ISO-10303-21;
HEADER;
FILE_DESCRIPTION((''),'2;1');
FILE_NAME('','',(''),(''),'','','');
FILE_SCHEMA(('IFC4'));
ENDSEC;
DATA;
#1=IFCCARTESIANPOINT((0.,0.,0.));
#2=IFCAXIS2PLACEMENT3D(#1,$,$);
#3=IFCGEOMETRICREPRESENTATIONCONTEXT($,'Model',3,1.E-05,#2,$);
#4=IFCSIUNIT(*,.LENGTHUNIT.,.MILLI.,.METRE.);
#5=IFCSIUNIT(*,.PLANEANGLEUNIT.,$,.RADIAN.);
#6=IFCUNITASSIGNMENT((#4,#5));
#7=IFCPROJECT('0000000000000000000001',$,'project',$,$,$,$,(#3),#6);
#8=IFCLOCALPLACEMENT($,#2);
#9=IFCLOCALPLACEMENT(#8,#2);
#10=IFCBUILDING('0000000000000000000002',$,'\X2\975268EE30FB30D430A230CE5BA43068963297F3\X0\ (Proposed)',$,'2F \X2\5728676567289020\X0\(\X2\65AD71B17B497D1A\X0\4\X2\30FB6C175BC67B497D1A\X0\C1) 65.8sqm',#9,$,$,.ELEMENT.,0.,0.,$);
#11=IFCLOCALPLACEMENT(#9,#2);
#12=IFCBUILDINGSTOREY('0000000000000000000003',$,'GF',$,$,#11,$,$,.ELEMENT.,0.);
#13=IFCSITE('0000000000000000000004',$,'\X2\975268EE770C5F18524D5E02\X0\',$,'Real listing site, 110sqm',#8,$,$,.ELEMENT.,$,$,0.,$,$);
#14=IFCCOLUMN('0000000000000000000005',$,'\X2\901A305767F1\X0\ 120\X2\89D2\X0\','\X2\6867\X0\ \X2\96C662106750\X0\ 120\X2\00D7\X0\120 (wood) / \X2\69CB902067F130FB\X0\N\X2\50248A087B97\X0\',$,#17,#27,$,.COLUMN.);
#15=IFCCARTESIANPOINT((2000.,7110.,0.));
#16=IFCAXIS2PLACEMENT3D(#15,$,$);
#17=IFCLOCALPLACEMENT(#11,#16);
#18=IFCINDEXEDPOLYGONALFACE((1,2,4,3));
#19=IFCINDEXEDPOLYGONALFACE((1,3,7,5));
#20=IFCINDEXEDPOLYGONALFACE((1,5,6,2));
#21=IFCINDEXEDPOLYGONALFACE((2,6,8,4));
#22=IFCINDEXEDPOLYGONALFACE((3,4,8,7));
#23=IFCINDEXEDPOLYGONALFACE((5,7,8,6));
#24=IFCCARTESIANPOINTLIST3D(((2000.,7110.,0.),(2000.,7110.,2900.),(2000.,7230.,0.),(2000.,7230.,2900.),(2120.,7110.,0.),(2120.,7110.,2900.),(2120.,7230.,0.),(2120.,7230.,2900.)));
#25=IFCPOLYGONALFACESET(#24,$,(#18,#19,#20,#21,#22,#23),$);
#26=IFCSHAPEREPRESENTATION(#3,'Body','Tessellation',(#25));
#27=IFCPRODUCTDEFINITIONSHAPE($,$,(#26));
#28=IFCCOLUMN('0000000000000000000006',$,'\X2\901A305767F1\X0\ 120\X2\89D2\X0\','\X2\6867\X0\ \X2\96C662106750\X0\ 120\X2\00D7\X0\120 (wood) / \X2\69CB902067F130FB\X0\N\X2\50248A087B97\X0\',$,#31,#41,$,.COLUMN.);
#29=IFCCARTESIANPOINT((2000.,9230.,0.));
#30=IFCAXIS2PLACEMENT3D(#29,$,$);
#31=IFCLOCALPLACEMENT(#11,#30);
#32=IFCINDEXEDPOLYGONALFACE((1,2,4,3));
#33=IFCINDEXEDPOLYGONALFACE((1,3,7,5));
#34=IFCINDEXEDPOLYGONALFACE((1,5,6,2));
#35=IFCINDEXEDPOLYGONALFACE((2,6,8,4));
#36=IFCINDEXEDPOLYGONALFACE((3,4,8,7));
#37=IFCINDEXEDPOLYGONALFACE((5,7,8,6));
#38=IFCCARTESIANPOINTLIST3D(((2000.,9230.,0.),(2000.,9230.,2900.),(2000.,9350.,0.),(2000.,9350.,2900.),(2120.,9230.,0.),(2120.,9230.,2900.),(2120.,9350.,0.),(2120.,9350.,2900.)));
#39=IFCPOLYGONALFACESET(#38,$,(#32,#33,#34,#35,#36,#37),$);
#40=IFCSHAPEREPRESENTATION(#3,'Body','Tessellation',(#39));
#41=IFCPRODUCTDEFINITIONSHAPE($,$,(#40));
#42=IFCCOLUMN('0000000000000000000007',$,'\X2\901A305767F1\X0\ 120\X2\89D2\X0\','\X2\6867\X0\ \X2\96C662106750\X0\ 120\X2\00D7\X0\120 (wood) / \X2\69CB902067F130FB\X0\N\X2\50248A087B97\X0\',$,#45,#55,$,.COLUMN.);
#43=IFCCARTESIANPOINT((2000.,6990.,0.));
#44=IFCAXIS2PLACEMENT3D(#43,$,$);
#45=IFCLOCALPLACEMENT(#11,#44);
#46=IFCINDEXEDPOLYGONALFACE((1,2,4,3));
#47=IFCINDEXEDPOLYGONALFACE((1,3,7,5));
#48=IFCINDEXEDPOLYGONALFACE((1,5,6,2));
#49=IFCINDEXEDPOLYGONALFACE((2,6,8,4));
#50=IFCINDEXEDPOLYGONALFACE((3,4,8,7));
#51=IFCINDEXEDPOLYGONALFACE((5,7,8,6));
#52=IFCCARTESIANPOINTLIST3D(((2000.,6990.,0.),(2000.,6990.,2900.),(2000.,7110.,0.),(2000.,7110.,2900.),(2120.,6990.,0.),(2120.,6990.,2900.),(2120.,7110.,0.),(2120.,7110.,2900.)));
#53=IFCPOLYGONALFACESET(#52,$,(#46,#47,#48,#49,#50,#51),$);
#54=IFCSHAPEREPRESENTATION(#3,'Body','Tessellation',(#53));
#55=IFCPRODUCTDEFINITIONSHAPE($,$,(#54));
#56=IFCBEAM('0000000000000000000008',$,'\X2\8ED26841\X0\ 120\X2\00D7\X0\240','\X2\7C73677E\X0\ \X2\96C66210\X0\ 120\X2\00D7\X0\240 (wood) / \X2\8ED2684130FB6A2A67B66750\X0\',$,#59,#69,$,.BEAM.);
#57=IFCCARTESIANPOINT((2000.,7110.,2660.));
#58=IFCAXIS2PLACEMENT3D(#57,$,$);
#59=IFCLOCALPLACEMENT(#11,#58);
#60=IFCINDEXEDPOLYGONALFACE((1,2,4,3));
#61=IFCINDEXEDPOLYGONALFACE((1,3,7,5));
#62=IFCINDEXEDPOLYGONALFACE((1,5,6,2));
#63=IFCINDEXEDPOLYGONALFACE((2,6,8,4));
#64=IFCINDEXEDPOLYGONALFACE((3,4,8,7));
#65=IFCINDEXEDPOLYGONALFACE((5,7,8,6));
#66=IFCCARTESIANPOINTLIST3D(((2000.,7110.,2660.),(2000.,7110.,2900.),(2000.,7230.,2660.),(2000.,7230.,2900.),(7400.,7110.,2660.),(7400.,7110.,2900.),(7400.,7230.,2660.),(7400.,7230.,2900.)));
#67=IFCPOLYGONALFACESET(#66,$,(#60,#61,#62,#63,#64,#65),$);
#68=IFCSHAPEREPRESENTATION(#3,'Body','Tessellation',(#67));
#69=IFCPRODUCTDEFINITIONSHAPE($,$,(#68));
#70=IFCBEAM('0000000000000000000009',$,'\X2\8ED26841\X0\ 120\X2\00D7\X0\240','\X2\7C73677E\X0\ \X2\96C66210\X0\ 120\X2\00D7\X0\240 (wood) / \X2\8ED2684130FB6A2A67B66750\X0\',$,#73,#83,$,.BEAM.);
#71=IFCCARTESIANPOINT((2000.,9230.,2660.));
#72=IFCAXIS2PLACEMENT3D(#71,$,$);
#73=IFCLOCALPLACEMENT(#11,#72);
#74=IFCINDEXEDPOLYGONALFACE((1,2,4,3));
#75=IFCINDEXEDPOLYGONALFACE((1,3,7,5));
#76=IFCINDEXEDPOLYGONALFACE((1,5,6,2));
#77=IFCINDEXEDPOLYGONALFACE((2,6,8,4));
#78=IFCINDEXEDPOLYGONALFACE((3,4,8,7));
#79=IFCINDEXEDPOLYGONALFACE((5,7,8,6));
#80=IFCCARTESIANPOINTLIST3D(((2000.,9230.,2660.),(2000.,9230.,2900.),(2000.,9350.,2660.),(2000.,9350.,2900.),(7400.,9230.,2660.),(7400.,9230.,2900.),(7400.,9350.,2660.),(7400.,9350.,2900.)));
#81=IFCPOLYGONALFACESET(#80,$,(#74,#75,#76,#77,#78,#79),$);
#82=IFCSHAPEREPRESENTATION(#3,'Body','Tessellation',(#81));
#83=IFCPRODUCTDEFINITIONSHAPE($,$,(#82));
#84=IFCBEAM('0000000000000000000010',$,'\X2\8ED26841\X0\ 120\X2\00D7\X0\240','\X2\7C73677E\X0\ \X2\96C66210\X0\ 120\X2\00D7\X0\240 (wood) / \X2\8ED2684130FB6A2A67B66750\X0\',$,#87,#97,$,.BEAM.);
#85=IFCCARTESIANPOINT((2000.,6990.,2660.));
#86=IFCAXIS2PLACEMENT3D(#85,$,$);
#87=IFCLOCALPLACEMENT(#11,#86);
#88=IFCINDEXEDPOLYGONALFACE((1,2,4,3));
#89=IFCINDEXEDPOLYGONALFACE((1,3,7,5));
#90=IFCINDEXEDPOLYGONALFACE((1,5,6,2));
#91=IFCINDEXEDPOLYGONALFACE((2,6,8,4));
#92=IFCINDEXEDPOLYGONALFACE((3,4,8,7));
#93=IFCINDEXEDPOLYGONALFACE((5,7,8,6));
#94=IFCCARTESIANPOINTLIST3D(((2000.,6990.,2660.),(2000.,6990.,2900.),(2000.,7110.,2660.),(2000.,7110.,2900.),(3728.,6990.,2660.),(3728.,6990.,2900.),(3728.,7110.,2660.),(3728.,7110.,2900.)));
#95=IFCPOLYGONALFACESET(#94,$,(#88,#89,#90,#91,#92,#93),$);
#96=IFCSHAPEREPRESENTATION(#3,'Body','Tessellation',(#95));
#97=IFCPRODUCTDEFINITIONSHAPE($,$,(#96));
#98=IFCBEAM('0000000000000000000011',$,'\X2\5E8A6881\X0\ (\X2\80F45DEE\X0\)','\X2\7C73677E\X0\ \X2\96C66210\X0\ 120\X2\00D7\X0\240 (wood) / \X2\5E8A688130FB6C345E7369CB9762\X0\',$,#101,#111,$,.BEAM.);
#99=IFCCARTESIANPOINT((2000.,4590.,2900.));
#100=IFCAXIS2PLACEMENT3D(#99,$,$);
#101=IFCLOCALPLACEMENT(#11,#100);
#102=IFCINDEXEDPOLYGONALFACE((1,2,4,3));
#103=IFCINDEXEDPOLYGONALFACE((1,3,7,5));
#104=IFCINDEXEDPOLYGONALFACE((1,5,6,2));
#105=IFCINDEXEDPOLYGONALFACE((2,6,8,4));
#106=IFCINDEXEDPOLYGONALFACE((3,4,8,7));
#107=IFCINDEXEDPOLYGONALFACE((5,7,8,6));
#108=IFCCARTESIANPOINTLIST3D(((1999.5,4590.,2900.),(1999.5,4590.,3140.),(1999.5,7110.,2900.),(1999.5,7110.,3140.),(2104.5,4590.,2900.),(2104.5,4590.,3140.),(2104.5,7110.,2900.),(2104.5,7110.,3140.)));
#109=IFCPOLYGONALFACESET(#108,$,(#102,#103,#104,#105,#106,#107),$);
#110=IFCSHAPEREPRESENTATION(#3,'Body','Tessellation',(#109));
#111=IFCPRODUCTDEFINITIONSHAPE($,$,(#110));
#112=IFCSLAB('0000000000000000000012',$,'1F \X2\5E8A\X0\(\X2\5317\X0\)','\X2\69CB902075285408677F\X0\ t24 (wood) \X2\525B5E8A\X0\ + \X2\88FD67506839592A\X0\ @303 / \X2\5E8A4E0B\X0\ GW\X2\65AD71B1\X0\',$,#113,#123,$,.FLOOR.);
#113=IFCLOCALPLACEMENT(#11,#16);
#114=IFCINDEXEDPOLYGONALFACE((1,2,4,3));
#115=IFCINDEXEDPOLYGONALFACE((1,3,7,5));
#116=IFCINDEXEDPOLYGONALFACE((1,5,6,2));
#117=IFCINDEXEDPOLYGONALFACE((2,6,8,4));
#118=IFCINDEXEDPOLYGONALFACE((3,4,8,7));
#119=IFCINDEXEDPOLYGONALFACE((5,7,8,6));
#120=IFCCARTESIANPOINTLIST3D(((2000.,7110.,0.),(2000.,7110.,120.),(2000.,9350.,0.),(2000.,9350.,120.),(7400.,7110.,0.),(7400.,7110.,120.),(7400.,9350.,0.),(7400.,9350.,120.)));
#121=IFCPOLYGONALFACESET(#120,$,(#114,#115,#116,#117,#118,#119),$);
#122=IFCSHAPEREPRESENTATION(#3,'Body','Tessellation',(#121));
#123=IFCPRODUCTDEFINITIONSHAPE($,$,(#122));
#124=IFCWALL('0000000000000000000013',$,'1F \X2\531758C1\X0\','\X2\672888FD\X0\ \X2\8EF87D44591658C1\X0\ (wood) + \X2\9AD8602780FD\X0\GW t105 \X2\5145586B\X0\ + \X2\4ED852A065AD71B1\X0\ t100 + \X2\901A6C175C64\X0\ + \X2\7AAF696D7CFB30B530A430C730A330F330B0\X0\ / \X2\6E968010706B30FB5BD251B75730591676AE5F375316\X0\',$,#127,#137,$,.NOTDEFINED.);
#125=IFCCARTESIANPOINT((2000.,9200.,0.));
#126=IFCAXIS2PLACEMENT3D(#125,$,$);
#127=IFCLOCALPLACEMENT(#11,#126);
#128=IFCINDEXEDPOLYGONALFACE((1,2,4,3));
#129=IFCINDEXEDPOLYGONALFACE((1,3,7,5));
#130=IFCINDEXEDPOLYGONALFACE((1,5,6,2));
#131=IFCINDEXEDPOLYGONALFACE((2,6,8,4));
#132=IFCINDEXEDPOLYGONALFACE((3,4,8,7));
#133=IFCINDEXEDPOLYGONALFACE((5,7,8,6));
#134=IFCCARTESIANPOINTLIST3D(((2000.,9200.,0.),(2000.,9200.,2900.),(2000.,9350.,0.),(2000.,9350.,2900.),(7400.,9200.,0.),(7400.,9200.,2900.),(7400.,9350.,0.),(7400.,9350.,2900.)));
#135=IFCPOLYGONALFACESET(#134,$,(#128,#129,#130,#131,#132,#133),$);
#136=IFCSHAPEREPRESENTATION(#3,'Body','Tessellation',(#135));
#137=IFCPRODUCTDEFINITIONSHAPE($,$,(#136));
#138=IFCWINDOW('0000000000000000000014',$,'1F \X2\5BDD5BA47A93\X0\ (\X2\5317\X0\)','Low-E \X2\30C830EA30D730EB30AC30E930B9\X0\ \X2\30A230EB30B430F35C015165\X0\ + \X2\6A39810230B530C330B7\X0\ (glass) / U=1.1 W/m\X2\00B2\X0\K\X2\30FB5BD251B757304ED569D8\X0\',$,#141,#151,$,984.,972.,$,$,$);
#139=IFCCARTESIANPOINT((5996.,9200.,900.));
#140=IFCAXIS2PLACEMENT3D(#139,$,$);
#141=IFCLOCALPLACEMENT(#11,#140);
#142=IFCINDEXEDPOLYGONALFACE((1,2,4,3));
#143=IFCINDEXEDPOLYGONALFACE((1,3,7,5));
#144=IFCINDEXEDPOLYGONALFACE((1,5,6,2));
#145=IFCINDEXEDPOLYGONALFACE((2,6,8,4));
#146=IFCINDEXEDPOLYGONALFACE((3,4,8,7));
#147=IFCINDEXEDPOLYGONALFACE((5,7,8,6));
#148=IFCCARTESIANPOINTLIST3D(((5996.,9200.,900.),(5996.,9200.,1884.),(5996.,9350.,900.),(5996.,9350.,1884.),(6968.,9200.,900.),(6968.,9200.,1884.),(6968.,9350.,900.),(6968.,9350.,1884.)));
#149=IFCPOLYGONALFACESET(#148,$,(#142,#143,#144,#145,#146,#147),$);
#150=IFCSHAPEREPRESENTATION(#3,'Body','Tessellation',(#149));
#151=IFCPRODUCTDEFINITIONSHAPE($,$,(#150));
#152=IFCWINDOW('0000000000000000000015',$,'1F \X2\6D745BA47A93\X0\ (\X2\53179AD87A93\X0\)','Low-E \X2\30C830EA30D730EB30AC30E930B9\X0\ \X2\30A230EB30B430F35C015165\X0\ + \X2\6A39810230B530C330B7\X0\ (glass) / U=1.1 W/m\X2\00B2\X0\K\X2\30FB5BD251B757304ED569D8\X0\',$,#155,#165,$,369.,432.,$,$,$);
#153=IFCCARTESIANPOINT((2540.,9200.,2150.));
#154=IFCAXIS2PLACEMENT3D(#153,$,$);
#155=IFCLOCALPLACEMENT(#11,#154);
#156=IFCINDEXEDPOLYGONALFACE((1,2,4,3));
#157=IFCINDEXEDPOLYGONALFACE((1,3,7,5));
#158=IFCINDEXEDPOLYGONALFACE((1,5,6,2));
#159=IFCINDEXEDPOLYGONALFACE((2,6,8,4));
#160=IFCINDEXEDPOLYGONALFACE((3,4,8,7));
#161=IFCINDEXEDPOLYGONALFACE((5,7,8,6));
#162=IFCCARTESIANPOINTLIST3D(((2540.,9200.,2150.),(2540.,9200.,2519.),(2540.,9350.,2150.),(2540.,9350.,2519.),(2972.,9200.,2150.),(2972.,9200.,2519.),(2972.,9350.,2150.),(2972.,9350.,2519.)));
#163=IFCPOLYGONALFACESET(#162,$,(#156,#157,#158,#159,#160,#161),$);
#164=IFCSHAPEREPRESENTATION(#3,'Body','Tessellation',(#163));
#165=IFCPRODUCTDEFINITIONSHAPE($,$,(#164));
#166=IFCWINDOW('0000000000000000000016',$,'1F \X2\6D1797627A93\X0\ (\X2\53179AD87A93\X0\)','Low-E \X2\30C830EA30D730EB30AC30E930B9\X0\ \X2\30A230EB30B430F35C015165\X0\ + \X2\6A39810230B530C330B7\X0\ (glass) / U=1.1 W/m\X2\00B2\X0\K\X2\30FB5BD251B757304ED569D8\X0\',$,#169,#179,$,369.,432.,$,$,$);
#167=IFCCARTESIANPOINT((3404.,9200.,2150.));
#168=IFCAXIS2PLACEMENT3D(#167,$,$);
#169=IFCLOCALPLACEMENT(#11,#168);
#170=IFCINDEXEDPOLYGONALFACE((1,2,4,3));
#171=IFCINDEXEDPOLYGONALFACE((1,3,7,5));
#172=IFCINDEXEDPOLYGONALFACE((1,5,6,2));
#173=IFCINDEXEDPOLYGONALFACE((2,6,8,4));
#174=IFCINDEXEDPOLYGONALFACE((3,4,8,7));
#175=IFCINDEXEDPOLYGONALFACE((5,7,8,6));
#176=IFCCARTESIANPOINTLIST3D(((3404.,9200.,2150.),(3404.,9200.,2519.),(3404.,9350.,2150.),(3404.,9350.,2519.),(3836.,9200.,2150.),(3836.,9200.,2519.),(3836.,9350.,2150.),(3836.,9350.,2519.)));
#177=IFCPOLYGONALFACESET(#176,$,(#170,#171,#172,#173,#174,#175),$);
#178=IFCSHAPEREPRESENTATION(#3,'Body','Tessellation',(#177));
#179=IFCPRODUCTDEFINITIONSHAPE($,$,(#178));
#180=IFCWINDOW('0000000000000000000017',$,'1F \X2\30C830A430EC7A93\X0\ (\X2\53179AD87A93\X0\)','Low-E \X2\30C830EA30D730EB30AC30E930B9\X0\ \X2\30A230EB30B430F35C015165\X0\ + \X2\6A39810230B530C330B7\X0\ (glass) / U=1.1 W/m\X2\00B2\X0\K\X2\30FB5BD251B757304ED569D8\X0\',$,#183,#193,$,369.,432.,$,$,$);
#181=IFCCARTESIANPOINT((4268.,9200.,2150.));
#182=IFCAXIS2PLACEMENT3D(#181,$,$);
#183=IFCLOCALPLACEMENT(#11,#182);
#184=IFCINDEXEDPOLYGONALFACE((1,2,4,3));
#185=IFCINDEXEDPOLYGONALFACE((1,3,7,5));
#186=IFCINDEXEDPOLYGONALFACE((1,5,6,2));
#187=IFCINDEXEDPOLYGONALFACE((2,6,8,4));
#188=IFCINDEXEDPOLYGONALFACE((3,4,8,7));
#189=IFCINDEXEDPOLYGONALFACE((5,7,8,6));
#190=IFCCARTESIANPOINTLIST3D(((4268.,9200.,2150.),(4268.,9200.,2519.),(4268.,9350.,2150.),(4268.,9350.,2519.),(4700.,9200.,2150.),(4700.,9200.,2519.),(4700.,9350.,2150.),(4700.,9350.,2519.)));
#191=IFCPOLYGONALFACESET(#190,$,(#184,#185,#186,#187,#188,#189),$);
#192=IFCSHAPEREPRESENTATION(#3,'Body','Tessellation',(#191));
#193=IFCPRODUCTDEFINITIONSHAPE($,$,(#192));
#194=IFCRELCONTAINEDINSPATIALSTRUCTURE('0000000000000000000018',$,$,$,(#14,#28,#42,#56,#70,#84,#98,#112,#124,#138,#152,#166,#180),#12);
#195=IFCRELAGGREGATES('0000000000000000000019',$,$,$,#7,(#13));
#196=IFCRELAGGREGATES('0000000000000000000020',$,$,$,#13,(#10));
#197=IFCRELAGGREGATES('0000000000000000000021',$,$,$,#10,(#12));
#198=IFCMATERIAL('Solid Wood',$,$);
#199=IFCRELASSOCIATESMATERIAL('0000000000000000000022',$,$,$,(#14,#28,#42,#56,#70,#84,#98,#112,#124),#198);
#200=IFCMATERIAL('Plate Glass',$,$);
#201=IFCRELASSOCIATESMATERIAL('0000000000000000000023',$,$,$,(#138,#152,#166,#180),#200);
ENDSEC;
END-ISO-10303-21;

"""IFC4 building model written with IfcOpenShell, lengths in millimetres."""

from ifc_helpers import new_model, si_unit, frame, frame_2d, origin, place, context, project, spatial, rectangle, extrude, material, element, fill, save


model = new_model("IFC4")

# Units and contexts
model_context = context("Model", 3, precision=1e-05, world=origin())
ifc_project = project(units=[si_unit("LENGTHUNIT", "METRE", prefix="MILLI"), si_unit("PLANEANGLEUNIT", "RADIAN")], contexts=[model_context])

# Site, building, storey
site_placement = place(None, origin())
site = spatial("IfcSite", under=ifc_project, at=site_placement, Name="青森県弘前市", ObjectType="Real listing site, 110sqm", CompositionType="ELEMENT", RefElevation=0.0)
building_placement = place(site_placement, origin())
building = spatial("IfcBuilding", under=site, at=building_placement, Name="青森・ピアノ室と防音 (Proposed)", ObjectType="2F 在来木造(断熱等級4・気密等級C1) 65.8sqm", CompositionType="ELEMENT", ElevationOfRefHeight=0.0, ElevationOfTerrain=0.0)
storey_placement = place(building_placement, origin())
storey = spatial("IfcBuildingStorey", under=building, at=storey_placement, Name="GF", CompositionType="ELEMENT", Elevation=0.0)

# Columns
ifc_material_1 = material(Name="Solid Wood")
column_1_placement = place(storey_placement, frame((2000.0, 7110.0, 0.0)))
element("IfcColumn", 1, at=column_1_placement, inside=storey, material=ifc_material_1, Name="通し柱 120角", Description="桧 集成材 120×120 (wood) / 構造柱・N値計算", PredefinedType="COLUMN", context=model_context, shape_type="SweptSolid", body=[
    extrude(rectangle(XDim=120.0, YDim=120.0, at=frame_2d((60.0, 60.0))), frame((2000.0, 7110.0, 0.0)), (0.0, 0.0, 1.0), 2900.0),
])
column_2_placement = place(storey_placement, frame((2000.0, 9230.0, 0.0)))
element("IfcColumn", 2, at=column_2_placement, inside=storey, material=ifc_material_1, Name="通し柱 120角", Description="桧 集成材 120×120 (wood) / 構造柱・N値計算", PredefinedType="COLUMN", context=model_context, shape_type="SweptSolid", body=[
    extrude(rectangle(XDim=120.0, YDim=120.0, at=frame_2d((60.0, 60.0))), frame((2000.0, 9230.0, 0.0)), (0.0, 0.0, 1.0), 2900.0),
])
column_3_placement = place(storey_placement, frame((2000.0, 6990.0, 0.0)))
element("IfcColumn", 3, at=column_3_placement, inside=storey, material=ifc_material_1, Name="通し柱 120角", Description="桧 集成材 120×120 (wood) / 構造柱・N値計算", PredefinedType="COLUMN", context=model_context, shape_type="SweptSolid", body=[
    extrude(rectangle(XDim=120.0, YDim=120.0, at=frame_2d((60.0, 60.0))), frame((2000.0, 6990.0, 0.0)), (0.0, 0.0, 1.0), 2900.0),
])

# Beams
beam_1_placement = place(storey_placement, frame((2000.0, 7110.0, 2660.0)))
element("IfcBeam", 4, at=beam_1_placement, inside=storey, material=ifc_material_1, Name="軒桁 120×240", Description="米松 集成 120×240 (wood) / 軒桁・横架材", PredefinedType="BEAM", context=model_context, shape_type="SweptSolid", body=[
    extrude(rectangle(XDim=5400.0, YDim=120.0, at=frame_2d((2700.0, 60.0))), frame((2000.0, 7110.0, 2660.0)), (0.0, 0.0, 1.0), 240.0),
])
beam_2_placement = place(storey_placement, frame((2000.0, 9230.0, 2660.0)))
element("IfcBeam", 5, at=beam_2_placement, inside=storey, material=ifc_material_1, Name="軒桁 120×240", Description="米松 集成 120×240 (wood) / 軒桁・横架材", PredefinedType="BEAM", context=model_context, shape_type="SweptSolid", body=[
    extrude(rectangle(XDim=5400.0, YDim=120.0, at=frame_2d((2700.0, 60.0))), frame((2000.0, 9230.0, 2660.0)), (0.0, 0.0, 1.0), 240.0),
])
beam_3_placement = place(storey_placement, frame((2000.0, 6990.0, 2660.0)))
element("IfcBeam", 6, at=beam_3_placement, inside=storey, material=ifc_material_1, Name="軒桁 120×240", Description="米松 集成 120×240 (wood) / 軒桁・横架材", PredefinedType="BEAM", context=model_context, shape_type="SweptSolid", body=[
    extrude(rectangle(XDim=1728.0, YDim=120.0, at=frame_2d((864.0, 60.0))), frame((2000.0, 6990.0, 2660.0)), (0.0, 0.0, 1.0), 240.0),
])
beam_4_placement = place(storey_placement, frame((2000.0, 4590.0, 2900.0)))
element("IfcBeam", 7, at=beam_4_placement, inside=storey, material=ifc_material_1, Name="床梁 (胴差)", Description="米松 集成 120×240 (wood) / 床梁・水平構面", PredefinedType="BEAM", context=model_context, shape_type="SweptSolid", body=[
    extrude(rectangle(XDim=105.0, YDim=2520.0, at=frame_2d((52.0, 1260.0))), frame((2000.0, 4590.0, 2900.0)), (0.0, 0.0, 1.0), 240.0),
])

# Slab
slab_placement = place(storey_placement, frame((2000.0, 7110.0, 0.0)))
element("IfcSlab", 8, at=slab_placement, inside=storey, material=ifc_material_1, Name="1F 床(北)", Description="構造用合板 t24 (wood) 剛床 + 製材根太 @303 / 床下 GW断熱", PredefinedType="FLOOR", context=model_context, shape_type="SweptSolid", body=[
    extrude(rectangle(XDim=5400.0, YDim=2240.0, at=frame_2d((2700.0, 1120.0))), frame((2000.0, 7110.0, 0.0)), (0.0, 0.0, 1.0), 120.0),
])

# Wall, openings, windows
wall_1_placement = place(storey_placement, frame((2000.0, 9200.0, 0.0)))
wall_1 = element("IfcWall", 9, at=wall_1_placement, inside=storey, material=ifc_material_1, Name="1F 北壁", Description="木製 軸組外壁 (wood) + 高性能GW t105 充填 + 付加断熱 t100 + 通気層 + 窯業系サイディング / 準耐火・寒冷地外皮強化", PredefinedType="NOTDEFINED", context=model_context, shape_type="SweptSolid", body=[
    extrude(rectangle(XDim=5400.0, YDim=150.0, at=frame_2d((2700.0, 75.0))), frame((2000.0, 9200.0, 0.0)), (0.0, 0.0, 1.0), 2900.0),
])
opening_1_placement = place(storey_placement, frame((5996.0, 9200.0, 900.0)))
opening_1 = element("IfcOpeningElement", 10, at=opening_1_placement, cuts=wall_1, PredefinedType="NOTDEFINED", context=model_context, shape_type="SweptSolid", body=[
    extrude(rectangle(XDim=972.0, YDim=150.0, at=frame_2d((486.0, 75.0))), frame((5996.0, 9200.0, 900.0)), (0.0, 0.0, 1.0), 984.0),
])
opening_2_placement = place(storey_placement, frame((2540.0, 9200.0, 2150.0)))
opening_2 = element("IfcOpeningElement", 11, at=opening_2_placement, cuts=wall_1, PredefinedType="NOTDEFINED", context=model_context, shape_type="SweptSolid", body=[
    extrude(rectangle(XDim=432.0, YDim=150.0, at=frame_2d((216.0, 75.0))), frame((2540.0, 9200.0, 2150.0)), (0.0, 0.0, 1.0), 369.0),
])
opening_3_placement = place(storey_placement, frame((3404.0, 9200.0, 2150.0)))
opening_3 = element("IfcOpeningElement", 12, at=opening_3_placement, cuts=wall_1, PredefinedType="NOTDEFINED", context=model_context, shape_type="SweptSolid", body=[
    extrude(rectangle(XDim=432.0, YDim=150.0, at=frame_2d((216.0, 75.0))), frame((3404.0, 9200.0, 2150.0)), (0.0, 0.0, 1.0), 369.0),
])
opening_4_placement = place(storey_placement, frame((4268.0, 9200.0, 2150.0)))
opening_4 = element("IfcOpeningElement", 13, at=opening_4_placement, cuts=wall_1, PredefinedType="NOTDEFINED", context=model_context, shape_type="SweptSolid", body=[
    extrude(rectangle(XDim=432.0, YDim=150.0, at=frame_2d((216.0, 75.0))), frame((4268.0, 9200.0, 2150.0)), (0.0, 0.0, 1.0), 369.0),
])
ifc_material_2 = material(Name="Plate Glass")
window_1_placement = place(storey_placement, frame((5996.0, 9200.0, 900.0)))
window_1 = element("IfcWindow", 14, at=window_1_placement, inside=storey, material=ifc_material_2, Name="1F 寝室窓 (北)", Description="Low-E トリプルガラス アルゴン封入 + 樹脂サッシ (glass) / U=1.1 W/m²K・寒冷地仕様", OverallHeight=984.0, OverallWidth=972.0, context=model_context, shape_type="SweptSolid", body=[
    extrude(rectangle(XDim=972.0, YDim=150.0, at=frame_2d((486.0, 75.0))), frame((5996.0, 9200.0, 900.0)), (0.0, 0.0, 1.0), 984.0),
])
fill(opening_1, window_1)
window_2_placement = place(storey_placement, frame((2540.0, 9200.0, 2150.0)))
window_2 = element("IfcWindow", 15, at=window_2_placement, inside=storey, material=ifc_material_2, Name="1F 浴室窓 (北高窓)", Description="Low-E トリプルガラス アルゴン封入 + 樹脂サッシ (glass) / U=1.1 W/m²K・寒冷地仕様", OverallHeight=369.0, OverallWidth=432.0, context=model_context, shape_type="SweptSolid", body=[
    extrude(rectangle(XDim=432.0, YDim=150.0, at=frame_2d((216.0, 75.0))), frame((2540.0, 9200.0, 2150.0)), (0.0, 0.0, 1.0), 369.0),
])
fill(opening_2, window_2)
window_3_placement = place(storey_placement, frame((3404.0, 9200.0, 2150.0)))
window_3 = element("IfcWindow", 16, at=window_3_placement, inside=storey, material=ifc_material_2, Name="1F 洗面窓 (北高窓)", Description="Low-E トリプルガラス アルゴン封入 + 樹脂サッシ (glass) / U=1.1 W/m²K・寒冷地仕様", OverallHeight=369.0, OverallWidth=432.0, context=model_context, shape_type="SweptSolid", body=[
    extrude(rectangle(XDim=432.0, YDim=150.0, at=frame_2d((216.0, 75.0))), frame((3404.0, 9200.0, 2150.0)), (0.0, 0.0, 1.0), 369.0),
])
fill(opening_3, window_3)
window_4_placement = place(storey_placement, frame((4268.0, 9200.0, 2150.0)))
window_4 = element("IfcWindow", 17, at=window_4_placement, inside=storey, material=ifc_material_2, Name="1F トイレ窓 (北高窓)", Description="Low-E トリプルガラス アルゴン封入 + 樹脂サッシ (glass) / U=1.1 W/m²K・寒冷地仕様", OverallHeight=369.0, OverallWidth=432.0, context=model_context, shape_type="SweptSolid", body=[
    extrude(rectangle(XDim=432.0, YDim=150.0, at=frame_2d((216.0, 75.0))), frame((4268.0, 9200.0, 2150.0)), (0.0, 0.0, 1.0), 369.0),
])
fill(opening_4, window_4)

save(model, "model.ifc")
